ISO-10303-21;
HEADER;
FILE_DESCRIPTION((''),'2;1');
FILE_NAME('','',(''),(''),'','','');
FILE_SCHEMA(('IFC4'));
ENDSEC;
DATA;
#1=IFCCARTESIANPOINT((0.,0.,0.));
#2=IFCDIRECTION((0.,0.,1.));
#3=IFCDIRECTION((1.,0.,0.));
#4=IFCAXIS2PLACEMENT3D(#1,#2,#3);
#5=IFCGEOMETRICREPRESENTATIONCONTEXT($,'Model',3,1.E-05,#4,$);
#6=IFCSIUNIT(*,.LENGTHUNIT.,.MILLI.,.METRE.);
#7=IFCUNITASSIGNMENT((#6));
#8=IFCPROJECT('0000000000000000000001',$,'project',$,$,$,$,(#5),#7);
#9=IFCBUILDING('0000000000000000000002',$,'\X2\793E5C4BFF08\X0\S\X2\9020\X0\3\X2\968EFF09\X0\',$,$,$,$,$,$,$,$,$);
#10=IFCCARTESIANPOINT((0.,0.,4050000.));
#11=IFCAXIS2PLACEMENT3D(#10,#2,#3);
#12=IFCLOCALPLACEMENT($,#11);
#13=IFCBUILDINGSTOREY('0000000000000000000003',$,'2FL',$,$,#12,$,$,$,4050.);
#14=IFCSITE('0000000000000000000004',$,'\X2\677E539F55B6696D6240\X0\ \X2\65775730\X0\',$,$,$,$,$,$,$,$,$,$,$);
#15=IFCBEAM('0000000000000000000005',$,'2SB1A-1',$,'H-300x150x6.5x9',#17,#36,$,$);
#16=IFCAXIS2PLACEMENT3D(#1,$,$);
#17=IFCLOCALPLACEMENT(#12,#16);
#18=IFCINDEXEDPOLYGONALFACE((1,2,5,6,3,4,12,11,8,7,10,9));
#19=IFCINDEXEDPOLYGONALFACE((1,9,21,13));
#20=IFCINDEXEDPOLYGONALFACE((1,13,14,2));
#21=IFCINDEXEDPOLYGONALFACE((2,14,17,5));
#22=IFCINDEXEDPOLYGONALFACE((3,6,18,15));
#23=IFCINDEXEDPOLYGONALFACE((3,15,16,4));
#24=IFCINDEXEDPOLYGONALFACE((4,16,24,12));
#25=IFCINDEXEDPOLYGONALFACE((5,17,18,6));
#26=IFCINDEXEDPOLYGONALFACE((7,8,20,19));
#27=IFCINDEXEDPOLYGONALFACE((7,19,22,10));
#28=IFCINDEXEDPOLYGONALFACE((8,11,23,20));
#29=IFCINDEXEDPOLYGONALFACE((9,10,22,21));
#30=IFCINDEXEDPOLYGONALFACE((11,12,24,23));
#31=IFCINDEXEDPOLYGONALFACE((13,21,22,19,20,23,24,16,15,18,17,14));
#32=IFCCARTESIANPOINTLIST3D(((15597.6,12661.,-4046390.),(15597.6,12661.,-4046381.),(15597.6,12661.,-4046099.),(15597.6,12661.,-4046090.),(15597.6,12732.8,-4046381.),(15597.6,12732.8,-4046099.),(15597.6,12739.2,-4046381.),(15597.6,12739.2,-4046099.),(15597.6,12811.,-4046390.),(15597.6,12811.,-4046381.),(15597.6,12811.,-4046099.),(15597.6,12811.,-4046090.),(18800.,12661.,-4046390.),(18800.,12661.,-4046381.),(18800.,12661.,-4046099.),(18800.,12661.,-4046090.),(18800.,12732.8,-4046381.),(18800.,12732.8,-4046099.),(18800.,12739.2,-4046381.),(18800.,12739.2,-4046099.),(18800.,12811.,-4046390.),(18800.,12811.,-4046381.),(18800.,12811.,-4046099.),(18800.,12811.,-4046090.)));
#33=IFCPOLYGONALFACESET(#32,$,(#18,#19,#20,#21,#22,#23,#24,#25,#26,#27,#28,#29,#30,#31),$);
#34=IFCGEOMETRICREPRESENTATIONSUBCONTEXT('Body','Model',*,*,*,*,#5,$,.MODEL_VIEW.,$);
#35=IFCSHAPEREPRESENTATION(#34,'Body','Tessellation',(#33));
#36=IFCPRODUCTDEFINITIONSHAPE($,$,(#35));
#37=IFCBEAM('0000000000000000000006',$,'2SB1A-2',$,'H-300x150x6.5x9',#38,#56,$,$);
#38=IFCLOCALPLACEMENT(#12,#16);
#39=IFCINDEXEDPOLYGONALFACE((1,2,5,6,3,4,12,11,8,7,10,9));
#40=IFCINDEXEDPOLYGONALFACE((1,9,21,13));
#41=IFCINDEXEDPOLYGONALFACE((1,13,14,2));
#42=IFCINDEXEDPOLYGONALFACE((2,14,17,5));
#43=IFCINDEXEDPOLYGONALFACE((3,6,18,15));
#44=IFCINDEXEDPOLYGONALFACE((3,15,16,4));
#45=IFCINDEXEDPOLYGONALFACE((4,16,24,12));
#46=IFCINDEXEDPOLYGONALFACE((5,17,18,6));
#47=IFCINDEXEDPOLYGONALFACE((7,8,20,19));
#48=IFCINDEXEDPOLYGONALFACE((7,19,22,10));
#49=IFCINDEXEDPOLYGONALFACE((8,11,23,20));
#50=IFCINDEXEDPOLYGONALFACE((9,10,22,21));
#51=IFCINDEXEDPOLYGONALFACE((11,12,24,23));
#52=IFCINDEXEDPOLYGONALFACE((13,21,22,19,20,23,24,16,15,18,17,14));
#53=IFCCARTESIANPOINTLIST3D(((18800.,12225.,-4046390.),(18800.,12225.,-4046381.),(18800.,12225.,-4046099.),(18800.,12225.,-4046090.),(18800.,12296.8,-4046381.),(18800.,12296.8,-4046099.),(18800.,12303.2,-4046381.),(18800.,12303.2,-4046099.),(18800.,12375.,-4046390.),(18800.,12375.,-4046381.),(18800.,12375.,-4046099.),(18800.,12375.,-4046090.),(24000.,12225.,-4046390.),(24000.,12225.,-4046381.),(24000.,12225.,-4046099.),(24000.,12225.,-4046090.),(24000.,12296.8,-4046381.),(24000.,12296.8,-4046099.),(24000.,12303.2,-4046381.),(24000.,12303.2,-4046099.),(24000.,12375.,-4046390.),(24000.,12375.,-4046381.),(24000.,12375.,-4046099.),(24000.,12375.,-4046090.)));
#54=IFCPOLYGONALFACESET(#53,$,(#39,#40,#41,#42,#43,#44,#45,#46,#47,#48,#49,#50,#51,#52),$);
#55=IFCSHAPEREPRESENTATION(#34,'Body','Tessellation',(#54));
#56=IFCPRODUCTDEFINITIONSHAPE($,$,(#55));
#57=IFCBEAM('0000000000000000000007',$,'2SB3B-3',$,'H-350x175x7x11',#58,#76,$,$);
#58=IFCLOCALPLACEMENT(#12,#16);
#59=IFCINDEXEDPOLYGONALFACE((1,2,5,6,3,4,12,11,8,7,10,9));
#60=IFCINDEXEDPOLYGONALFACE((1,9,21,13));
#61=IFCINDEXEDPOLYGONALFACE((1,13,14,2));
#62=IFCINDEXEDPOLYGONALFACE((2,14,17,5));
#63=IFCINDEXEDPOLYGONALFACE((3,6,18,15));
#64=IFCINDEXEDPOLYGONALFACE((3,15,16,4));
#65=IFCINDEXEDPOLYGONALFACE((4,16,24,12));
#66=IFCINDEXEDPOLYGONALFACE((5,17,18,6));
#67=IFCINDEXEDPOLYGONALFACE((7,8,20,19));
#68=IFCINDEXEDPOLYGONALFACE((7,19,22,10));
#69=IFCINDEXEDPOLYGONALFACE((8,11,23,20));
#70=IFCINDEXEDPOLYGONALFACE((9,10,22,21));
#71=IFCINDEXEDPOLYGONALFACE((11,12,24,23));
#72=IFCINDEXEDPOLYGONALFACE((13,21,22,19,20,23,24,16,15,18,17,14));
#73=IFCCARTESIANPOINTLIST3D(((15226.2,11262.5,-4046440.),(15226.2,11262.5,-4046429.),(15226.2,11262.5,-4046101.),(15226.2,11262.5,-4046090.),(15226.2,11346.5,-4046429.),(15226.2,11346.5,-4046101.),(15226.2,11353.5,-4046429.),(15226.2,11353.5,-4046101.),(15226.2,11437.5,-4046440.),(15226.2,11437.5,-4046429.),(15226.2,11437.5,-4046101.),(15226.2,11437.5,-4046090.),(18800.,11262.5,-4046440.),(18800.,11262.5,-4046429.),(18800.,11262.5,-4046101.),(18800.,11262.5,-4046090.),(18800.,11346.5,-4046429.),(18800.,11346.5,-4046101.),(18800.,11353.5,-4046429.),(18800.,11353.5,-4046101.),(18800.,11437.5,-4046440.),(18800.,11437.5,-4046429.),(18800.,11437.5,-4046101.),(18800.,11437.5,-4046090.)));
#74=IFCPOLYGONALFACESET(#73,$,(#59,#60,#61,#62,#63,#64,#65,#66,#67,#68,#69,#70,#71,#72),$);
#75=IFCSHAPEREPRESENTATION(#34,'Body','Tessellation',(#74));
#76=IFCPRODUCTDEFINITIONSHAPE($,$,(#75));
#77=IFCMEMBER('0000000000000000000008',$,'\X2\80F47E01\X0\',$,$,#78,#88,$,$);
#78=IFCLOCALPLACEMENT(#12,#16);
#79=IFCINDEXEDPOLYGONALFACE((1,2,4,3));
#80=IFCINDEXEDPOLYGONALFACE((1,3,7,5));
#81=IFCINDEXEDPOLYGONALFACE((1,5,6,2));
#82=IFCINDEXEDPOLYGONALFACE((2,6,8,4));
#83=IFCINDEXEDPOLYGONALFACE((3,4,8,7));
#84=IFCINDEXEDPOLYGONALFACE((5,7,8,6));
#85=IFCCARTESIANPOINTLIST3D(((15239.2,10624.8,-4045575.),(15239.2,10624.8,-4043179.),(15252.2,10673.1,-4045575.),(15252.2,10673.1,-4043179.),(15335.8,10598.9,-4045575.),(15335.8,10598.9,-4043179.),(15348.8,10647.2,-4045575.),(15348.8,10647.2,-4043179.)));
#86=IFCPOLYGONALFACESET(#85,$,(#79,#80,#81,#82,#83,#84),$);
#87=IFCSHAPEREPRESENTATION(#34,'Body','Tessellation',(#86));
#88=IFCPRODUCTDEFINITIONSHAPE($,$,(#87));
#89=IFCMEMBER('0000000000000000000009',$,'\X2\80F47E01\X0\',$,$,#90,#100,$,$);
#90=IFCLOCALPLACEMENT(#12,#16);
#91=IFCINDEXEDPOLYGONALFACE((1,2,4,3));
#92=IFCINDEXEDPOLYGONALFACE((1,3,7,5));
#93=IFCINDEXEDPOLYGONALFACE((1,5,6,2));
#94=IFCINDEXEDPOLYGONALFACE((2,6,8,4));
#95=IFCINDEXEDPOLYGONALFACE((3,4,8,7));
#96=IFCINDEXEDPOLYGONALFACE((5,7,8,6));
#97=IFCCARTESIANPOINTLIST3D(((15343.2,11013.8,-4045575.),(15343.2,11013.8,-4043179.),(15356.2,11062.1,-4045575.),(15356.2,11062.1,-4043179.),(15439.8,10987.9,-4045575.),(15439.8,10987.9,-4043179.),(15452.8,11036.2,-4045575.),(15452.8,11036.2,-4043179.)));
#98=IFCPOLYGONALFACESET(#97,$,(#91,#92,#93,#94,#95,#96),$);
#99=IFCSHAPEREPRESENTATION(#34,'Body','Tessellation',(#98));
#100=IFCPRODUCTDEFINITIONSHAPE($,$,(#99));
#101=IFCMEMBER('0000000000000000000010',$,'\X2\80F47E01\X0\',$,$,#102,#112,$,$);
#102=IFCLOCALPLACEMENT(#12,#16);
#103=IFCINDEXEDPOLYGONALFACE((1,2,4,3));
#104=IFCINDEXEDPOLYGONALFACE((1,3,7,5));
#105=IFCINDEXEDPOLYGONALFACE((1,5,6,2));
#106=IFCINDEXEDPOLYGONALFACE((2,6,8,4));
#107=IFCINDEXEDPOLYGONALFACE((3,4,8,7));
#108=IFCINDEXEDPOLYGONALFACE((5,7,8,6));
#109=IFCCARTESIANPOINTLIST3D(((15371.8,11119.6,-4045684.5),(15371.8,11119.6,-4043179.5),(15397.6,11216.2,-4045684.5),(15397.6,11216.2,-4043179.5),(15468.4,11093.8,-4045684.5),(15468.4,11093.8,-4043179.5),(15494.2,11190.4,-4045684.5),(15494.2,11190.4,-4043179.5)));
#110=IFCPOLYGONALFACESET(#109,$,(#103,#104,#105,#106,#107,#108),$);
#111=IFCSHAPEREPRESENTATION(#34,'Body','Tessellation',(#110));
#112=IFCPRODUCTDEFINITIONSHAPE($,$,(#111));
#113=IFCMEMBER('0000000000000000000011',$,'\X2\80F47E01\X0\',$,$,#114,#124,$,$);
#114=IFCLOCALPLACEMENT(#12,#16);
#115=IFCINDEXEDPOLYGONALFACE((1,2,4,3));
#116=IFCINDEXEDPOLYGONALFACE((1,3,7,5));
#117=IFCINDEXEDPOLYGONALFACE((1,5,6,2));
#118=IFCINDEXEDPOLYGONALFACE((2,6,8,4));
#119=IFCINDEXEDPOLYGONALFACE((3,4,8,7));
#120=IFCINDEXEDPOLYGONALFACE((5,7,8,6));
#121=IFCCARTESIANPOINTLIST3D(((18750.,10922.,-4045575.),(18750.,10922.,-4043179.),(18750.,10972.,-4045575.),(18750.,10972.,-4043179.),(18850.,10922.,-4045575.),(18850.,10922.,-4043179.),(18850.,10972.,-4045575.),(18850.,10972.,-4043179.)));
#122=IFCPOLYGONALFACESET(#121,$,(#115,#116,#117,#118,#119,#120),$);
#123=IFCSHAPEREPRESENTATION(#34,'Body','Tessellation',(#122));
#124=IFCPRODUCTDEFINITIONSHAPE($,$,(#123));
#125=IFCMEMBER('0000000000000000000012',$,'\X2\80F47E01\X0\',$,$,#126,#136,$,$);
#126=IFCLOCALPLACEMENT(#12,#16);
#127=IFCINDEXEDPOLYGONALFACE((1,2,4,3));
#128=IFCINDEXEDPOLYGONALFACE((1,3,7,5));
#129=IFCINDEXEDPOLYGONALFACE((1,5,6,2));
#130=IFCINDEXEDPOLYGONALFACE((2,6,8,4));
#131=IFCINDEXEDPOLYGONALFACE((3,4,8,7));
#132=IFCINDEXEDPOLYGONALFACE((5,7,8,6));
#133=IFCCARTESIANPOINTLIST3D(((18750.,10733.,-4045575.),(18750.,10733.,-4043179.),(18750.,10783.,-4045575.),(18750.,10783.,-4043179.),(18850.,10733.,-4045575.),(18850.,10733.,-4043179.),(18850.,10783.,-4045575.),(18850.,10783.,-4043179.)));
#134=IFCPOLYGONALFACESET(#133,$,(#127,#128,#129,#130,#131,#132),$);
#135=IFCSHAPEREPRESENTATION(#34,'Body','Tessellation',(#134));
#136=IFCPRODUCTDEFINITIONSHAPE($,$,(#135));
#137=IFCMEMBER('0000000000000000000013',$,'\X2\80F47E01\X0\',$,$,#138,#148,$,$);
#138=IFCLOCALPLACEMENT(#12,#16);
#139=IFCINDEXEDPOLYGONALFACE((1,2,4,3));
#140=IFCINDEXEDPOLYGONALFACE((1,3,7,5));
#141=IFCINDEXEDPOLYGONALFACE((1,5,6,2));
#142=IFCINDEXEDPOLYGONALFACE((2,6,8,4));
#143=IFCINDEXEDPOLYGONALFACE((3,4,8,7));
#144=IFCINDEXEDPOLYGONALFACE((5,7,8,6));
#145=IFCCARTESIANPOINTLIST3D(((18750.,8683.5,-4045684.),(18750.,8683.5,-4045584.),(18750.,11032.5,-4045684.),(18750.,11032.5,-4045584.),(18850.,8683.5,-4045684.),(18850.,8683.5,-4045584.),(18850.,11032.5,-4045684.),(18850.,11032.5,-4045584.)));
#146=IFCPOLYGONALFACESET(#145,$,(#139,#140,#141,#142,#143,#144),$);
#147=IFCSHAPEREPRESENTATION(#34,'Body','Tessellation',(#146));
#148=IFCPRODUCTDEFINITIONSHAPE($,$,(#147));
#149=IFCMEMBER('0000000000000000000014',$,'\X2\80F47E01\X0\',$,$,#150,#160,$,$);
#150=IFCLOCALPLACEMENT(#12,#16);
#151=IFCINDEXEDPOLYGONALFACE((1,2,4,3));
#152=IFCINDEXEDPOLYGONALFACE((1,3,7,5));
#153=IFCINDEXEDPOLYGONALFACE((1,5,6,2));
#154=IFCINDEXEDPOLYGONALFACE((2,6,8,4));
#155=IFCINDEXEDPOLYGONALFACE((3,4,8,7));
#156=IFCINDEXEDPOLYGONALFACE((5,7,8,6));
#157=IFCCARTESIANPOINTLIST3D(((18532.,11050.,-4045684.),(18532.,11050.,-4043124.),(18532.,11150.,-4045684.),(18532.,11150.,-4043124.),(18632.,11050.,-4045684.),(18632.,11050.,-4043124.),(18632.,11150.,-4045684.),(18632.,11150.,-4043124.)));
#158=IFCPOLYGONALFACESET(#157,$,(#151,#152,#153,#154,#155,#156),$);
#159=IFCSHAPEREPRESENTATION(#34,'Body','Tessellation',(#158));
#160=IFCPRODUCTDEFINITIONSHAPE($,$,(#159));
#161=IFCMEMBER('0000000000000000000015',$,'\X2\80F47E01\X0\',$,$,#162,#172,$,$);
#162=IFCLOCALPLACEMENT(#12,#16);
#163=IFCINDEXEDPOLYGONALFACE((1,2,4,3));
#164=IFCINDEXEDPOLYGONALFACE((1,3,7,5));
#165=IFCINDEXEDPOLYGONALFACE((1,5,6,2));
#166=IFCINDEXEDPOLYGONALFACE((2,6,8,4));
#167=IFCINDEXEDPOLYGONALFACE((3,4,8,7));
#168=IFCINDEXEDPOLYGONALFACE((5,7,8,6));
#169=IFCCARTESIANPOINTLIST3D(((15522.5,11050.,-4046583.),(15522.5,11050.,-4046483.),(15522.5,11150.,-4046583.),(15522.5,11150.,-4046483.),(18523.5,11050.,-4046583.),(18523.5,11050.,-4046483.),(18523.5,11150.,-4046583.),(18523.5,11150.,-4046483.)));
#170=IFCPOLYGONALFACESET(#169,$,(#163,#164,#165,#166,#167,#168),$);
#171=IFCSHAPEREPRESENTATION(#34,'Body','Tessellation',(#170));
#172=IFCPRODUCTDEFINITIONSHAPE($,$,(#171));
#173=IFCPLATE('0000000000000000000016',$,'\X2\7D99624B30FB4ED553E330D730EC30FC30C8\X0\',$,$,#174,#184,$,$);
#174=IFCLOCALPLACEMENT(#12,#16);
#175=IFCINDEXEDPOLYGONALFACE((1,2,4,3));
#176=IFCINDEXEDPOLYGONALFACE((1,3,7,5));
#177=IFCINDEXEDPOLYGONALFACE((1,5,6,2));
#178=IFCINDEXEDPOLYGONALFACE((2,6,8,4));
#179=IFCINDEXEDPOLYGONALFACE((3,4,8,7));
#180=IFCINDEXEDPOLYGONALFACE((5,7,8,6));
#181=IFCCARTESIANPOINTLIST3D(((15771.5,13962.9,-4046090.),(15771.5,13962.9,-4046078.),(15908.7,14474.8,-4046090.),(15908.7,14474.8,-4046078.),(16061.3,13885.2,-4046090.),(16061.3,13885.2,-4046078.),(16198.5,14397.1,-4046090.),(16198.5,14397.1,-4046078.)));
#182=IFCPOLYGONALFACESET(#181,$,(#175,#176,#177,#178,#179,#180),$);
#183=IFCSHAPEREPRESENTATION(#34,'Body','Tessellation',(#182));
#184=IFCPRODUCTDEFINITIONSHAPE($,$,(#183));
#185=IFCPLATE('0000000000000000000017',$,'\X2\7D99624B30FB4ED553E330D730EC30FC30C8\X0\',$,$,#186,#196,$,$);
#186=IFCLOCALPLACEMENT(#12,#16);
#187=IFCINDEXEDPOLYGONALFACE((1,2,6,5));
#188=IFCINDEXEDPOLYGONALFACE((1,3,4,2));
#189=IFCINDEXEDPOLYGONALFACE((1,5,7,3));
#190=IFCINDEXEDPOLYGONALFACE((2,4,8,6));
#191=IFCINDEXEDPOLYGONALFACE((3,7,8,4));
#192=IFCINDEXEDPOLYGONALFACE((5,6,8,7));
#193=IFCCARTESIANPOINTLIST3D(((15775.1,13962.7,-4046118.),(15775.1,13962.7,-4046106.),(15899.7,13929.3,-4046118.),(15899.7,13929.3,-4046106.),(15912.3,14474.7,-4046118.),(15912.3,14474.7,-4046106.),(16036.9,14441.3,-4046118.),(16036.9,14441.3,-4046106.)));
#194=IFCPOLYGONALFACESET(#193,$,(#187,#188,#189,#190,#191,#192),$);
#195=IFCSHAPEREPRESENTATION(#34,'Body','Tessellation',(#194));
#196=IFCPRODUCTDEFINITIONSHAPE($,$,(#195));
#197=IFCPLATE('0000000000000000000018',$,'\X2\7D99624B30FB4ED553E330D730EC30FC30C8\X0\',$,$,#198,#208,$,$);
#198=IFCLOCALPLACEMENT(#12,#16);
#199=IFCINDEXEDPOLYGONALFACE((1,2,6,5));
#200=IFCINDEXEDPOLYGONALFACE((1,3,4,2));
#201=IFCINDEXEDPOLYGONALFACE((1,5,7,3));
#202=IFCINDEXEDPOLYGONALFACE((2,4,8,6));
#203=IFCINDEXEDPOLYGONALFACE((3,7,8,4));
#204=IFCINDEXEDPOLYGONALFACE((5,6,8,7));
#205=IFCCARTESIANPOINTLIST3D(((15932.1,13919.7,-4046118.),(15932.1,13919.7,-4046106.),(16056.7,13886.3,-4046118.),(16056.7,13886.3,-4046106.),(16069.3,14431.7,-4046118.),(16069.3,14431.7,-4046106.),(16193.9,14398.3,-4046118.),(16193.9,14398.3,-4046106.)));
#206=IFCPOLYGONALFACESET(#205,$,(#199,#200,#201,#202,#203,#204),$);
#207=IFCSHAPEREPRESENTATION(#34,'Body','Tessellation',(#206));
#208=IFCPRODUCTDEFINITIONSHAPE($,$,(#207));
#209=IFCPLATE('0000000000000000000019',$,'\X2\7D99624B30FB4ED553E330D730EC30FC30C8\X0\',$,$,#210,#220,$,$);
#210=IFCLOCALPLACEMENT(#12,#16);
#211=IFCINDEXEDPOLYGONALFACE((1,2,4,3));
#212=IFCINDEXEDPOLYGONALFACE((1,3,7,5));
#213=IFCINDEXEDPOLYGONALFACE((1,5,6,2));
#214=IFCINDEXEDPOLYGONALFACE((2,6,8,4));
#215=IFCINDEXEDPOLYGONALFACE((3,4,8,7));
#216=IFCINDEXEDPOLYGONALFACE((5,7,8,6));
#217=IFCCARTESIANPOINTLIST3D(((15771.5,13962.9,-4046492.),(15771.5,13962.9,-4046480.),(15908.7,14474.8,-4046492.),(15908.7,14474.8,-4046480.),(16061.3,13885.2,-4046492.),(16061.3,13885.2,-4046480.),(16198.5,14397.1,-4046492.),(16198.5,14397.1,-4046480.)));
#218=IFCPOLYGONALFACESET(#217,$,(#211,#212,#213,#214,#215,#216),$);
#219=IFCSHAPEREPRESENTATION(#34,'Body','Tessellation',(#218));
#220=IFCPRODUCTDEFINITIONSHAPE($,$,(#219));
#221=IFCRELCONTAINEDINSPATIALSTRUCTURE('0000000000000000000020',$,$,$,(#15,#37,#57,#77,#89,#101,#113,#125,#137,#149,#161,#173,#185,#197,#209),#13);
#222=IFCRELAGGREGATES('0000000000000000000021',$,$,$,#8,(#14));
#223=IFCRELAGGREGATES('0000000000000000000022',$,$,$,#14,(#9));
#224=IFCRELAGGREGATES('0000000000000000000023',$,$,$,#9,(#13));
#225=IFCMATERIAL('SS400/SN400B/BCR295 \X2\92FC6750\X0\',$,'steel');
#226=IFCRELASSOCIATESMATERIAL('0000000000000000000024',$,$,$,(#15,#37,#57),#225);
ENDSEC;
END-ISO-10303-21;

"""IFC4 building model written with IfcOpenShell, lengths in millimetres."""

from ifc_helpers import new_model, si_unit, frame, origin, origin_with_axes, place, context, subcontext, project, spatial, rectangle, i_section, extrude, material, element, save


model = new_model("IFC4")

# Units and contexts
model_context = context("Model", 3, precision=1e-05, world=origin_with_axes())
body_context = subcontext(model_context, "Body", "Model", "MODEL_VIEW")
ifc_project = project(units=[si_unit("LENGTHUNIT", "METRE", prefix="MILLI")], contexts=[model_context])

# Site, building, storey
site = spatial("IfcSite", under=ifc_project, Name="松原営業所 敷地")
building = spatial("IfcBuilding", under=site, Name="社屋（S造3階）")
storey_placement = place(None, frame((0.0, 0.0, 4050000.0), z_axis=(0.0, 0.0, 1.0), x_axis=(1.0, 0.0, 0.0)))
storey = spatial("IfcBuildingStorey", under=building, at=storey_placement, Name="2FL", Elevation=4050.0)

# Beams
ifc_material = material(Name="SS400/SN400B/BCR295 鋼材", Category="steel")
beam_1_placement = place(storey_placement, frame((15597.6, 12736.0, -4046090.0), z_axis=(1.0, 0.0, 0.0), x_axis=(0.0, 1.0, 0.0)))
element("IfcBeam", 1, at=beam_1_placement, inside=storey, material=ifc_material, Name="2SB1A-1", ObjectType="H-300x150x6.5x9", context=body_context, shape_type="SweptSolid", body=[
    extrude(i_section(OverallWidth=150.0, OverallDepth=300.0, WebThickness=6.5, FlangeThickness=9.0), frame((0.0, -150.0, 0.0)), (0.0, 0.0, 1.0), 3202.4),
])
beam_2_placement = place(storey_placement, frame((18800.0, 12300.0, -4046090.0), z_axis=(1.0, 0.0, 0.0), x_axis=(0.0, 1.0, 0.0)))
element("IfcBeam", 2, at=beam_2_placement, inside=storey, material=ifc_material, Name="2SB1A-2", ObjectType="H-300x150x6.5x9", context=body_context, shape_type="SweptSolid", body=[
    extrude(i_section(OverallWidth=150.0, OverallDepth=300.0, WebThickness=6.5, FlangeThickness=9.0), frame((0.0, -150.0, 0.0)), (0.0, 0.0, 1.0), 5200.0),
])
beam_3_placement = place(storey_placement, frame((15226.2, 11350.0, -4046090.0), z_axis=(1.0, 0.0, 0.0), x_axis=(0.0, 1.0, 0.0)))
element("IfcBeam", 3, at=beam_3_placement, inside=storey, material=ifc_material, Name="2SB3B-3", ObjectType="H-350x175x7x11", context=body_context, shape_type="SweptSolid", body=[
    extrude(i_section(OverallWidth=175.0, OverallDepth=350.0, WebThickness=7.0, FlangeThickness=11.0), frame((0.0, -175.0, 0.0)), (0.0, 0.0, 1.0), 3573.8),
])

# Members
for number, where, z_axis, x_axis, name in (
    (4, (15287.5, 10611.9, -4044377.0), (0.258819, 0.965926, 0.0), (-0.965926, 0.258819, 0.0), "胴縁"),
    (5, (15391.5, 11000.9, -4044377.0), (0.258819, 0.965926, 0.0), (-0.965926, 0.258819, 0.0), "胴縁"),
):
    element("IfcMember", number, at=place(storey_placement, frame(where, z_axis=z_axis, x_axis=x_axis)), inside=storey, Name=name, context=body_context, shape_type="SweptSolid", body=[
        extrude(rectangle(XDim=100.0, YDim=2396.0), origin(), (0.0, 0.0, 1.0), 50.0),
    ])
member_1_placement = place(storey_placement, frame((15420.1, 11106.7, -4044432.0), z_axis=(0.258819, 0.965926, 0.0), x_axis=(-0.965926, 0.258819, 0.0)))
element("IfcMember", 6, at=member_1_placement, inside=storey, Name="胴縁", context=body_context, shape_type="SweptSolid", body=[
    extrude(rectangle(XDim=100.0, YDim=2505.0), origin(), (0.0, 0.0, 1.0), 100.0),
])
for number, where, z_axis, x_axis, name in (
    (7, (18800.0, 10972.0, -4044377.0), (0.0, -1.0, 0.0), (1.0, 0.0, 0.0), "胴縁"),
    (8, (18800.0, 10783.0, -4044377.0), (0.0, -1.0, 0.0), (1.0, 0.0, 0.0), "胴縁"),
):
    element("IfcMember", number, at=place(storey_placement, frame(where, z_axis=z_axis, x_axis=x_axis)), inside=storey, Name=name, context=body_context, shape_type="SweptSolid", body=[
        extrude(rectangle(XDim=100.0, YDim=2396.0), origin(), (0.0, 0.0, 1.0), 50.0),
    ])
member_2_placement = place(storey_placement, frame((18800.0, 11032.5, -4045634.0), z_axis=(0.0, -1.0, 0.0), x_axis=(1.0, 0.0, 0.0)))
element("IfcMember", 9, at=member_2_placement, inside=storey, Name="胴縁", context=body_context, shape_type="SweptSolid", body=[
    extrude(rectangle(XDim=100.0, YDim=100.0), origin(), (0.0, 0.0, 1.0), 2349.0),
])
member_3_placement = place(storey_placement, frame((18532.0, 11100.0, -4044404.0), z_axis=(1.0, 0.0, 0.0), x_axis=(0.0, 1.0, 0.0)))
element("IfcMember", 10, at=member_3_placement, inside=storey, Name="胴縁", context=body_context, shape_type="SweptSolid", body=[
    extrude(rectangle(XDim=100.0, YDim=2560.0), origin(), (0.0, 0.0, 1.0), 100.0),
])
member_4_placement = place(storey_placement, frame((15522.5, 11100.0, -4046533.0), z_axis=(1.0, 0.0, 0.0), x_axis=(0.0, 1.0, 0.0)))
element("IfcMember", 11, at=member_4_placement, inside=storey, Name="胴縁", context=body_context, shape_type="SweptSolid", body=[
    extrude(rectangle(XDim=100.0, YDim=100.0), origin(), (0.0, 0.0, 1.0), 3001.0),
])

# Plates
plate_1_placement = place(storey_placement, frame((15916.4, 13924.0, -4046084.0), z_axis=(0.258819, 0.965926, 0.0), x_axis=(-0.965926, 0.258819, 0.0)))
element("IfcPlate", 12, at=plate_1_placement, inside=storey, Name="継手・仕口プレート", context=body_context, shape_type="SweptSolid", body=[
    extrude(rectangle(XDim=300.0, YDim=12.0), origin(), (0.0, 0.0, 1.0), 530.0),
])
for number, where, z_axis, x_axis, name in (
    (13, (15837.4, 13946.0, -4046112.0), (0.258819, 0.965926, 0.0), (-0.965926, 0.258819, 0.0), "継手・仕口プレート"),
    (14, (15994.4, 13903.0, -4046112.0), (0.258819, 0.965926, 0.0), (-0.965926, 0.258819, 0.0), "継手・仕口プレート"),
):
    element("IfcPlate", number, at=place(storey_placement, frame(where, z_axis=z_axis, x_axis=x_axis)), inside=storey, Name=name, context=body_context, shape_type="SweptSolid", body=[
        extrude(rectangle(XDim=129.0, YDim=12.0), origin(), (0.0, 0.0, 1.0), 530.0),
    ])
plate_2_placement = place(storey_placement, frame((15916.4, 13924.0, -4046486.0), z_axis=(0.258819, 0.965926, 0.0), x_axis=(-0.965926, 0.258819, 0.0)))
element("IfcPlate", 15, at=plate_2_placement, inside=storey, Name="継手・仕口プレート", context=body_context, shape_type="SweptSolid", body=[
    extrude(rectangle(XDim=300.0, YDim=12.0), origin(), (0.0, 0.0, 1.0), 530.0),
])

save(model, "model.ifc")
